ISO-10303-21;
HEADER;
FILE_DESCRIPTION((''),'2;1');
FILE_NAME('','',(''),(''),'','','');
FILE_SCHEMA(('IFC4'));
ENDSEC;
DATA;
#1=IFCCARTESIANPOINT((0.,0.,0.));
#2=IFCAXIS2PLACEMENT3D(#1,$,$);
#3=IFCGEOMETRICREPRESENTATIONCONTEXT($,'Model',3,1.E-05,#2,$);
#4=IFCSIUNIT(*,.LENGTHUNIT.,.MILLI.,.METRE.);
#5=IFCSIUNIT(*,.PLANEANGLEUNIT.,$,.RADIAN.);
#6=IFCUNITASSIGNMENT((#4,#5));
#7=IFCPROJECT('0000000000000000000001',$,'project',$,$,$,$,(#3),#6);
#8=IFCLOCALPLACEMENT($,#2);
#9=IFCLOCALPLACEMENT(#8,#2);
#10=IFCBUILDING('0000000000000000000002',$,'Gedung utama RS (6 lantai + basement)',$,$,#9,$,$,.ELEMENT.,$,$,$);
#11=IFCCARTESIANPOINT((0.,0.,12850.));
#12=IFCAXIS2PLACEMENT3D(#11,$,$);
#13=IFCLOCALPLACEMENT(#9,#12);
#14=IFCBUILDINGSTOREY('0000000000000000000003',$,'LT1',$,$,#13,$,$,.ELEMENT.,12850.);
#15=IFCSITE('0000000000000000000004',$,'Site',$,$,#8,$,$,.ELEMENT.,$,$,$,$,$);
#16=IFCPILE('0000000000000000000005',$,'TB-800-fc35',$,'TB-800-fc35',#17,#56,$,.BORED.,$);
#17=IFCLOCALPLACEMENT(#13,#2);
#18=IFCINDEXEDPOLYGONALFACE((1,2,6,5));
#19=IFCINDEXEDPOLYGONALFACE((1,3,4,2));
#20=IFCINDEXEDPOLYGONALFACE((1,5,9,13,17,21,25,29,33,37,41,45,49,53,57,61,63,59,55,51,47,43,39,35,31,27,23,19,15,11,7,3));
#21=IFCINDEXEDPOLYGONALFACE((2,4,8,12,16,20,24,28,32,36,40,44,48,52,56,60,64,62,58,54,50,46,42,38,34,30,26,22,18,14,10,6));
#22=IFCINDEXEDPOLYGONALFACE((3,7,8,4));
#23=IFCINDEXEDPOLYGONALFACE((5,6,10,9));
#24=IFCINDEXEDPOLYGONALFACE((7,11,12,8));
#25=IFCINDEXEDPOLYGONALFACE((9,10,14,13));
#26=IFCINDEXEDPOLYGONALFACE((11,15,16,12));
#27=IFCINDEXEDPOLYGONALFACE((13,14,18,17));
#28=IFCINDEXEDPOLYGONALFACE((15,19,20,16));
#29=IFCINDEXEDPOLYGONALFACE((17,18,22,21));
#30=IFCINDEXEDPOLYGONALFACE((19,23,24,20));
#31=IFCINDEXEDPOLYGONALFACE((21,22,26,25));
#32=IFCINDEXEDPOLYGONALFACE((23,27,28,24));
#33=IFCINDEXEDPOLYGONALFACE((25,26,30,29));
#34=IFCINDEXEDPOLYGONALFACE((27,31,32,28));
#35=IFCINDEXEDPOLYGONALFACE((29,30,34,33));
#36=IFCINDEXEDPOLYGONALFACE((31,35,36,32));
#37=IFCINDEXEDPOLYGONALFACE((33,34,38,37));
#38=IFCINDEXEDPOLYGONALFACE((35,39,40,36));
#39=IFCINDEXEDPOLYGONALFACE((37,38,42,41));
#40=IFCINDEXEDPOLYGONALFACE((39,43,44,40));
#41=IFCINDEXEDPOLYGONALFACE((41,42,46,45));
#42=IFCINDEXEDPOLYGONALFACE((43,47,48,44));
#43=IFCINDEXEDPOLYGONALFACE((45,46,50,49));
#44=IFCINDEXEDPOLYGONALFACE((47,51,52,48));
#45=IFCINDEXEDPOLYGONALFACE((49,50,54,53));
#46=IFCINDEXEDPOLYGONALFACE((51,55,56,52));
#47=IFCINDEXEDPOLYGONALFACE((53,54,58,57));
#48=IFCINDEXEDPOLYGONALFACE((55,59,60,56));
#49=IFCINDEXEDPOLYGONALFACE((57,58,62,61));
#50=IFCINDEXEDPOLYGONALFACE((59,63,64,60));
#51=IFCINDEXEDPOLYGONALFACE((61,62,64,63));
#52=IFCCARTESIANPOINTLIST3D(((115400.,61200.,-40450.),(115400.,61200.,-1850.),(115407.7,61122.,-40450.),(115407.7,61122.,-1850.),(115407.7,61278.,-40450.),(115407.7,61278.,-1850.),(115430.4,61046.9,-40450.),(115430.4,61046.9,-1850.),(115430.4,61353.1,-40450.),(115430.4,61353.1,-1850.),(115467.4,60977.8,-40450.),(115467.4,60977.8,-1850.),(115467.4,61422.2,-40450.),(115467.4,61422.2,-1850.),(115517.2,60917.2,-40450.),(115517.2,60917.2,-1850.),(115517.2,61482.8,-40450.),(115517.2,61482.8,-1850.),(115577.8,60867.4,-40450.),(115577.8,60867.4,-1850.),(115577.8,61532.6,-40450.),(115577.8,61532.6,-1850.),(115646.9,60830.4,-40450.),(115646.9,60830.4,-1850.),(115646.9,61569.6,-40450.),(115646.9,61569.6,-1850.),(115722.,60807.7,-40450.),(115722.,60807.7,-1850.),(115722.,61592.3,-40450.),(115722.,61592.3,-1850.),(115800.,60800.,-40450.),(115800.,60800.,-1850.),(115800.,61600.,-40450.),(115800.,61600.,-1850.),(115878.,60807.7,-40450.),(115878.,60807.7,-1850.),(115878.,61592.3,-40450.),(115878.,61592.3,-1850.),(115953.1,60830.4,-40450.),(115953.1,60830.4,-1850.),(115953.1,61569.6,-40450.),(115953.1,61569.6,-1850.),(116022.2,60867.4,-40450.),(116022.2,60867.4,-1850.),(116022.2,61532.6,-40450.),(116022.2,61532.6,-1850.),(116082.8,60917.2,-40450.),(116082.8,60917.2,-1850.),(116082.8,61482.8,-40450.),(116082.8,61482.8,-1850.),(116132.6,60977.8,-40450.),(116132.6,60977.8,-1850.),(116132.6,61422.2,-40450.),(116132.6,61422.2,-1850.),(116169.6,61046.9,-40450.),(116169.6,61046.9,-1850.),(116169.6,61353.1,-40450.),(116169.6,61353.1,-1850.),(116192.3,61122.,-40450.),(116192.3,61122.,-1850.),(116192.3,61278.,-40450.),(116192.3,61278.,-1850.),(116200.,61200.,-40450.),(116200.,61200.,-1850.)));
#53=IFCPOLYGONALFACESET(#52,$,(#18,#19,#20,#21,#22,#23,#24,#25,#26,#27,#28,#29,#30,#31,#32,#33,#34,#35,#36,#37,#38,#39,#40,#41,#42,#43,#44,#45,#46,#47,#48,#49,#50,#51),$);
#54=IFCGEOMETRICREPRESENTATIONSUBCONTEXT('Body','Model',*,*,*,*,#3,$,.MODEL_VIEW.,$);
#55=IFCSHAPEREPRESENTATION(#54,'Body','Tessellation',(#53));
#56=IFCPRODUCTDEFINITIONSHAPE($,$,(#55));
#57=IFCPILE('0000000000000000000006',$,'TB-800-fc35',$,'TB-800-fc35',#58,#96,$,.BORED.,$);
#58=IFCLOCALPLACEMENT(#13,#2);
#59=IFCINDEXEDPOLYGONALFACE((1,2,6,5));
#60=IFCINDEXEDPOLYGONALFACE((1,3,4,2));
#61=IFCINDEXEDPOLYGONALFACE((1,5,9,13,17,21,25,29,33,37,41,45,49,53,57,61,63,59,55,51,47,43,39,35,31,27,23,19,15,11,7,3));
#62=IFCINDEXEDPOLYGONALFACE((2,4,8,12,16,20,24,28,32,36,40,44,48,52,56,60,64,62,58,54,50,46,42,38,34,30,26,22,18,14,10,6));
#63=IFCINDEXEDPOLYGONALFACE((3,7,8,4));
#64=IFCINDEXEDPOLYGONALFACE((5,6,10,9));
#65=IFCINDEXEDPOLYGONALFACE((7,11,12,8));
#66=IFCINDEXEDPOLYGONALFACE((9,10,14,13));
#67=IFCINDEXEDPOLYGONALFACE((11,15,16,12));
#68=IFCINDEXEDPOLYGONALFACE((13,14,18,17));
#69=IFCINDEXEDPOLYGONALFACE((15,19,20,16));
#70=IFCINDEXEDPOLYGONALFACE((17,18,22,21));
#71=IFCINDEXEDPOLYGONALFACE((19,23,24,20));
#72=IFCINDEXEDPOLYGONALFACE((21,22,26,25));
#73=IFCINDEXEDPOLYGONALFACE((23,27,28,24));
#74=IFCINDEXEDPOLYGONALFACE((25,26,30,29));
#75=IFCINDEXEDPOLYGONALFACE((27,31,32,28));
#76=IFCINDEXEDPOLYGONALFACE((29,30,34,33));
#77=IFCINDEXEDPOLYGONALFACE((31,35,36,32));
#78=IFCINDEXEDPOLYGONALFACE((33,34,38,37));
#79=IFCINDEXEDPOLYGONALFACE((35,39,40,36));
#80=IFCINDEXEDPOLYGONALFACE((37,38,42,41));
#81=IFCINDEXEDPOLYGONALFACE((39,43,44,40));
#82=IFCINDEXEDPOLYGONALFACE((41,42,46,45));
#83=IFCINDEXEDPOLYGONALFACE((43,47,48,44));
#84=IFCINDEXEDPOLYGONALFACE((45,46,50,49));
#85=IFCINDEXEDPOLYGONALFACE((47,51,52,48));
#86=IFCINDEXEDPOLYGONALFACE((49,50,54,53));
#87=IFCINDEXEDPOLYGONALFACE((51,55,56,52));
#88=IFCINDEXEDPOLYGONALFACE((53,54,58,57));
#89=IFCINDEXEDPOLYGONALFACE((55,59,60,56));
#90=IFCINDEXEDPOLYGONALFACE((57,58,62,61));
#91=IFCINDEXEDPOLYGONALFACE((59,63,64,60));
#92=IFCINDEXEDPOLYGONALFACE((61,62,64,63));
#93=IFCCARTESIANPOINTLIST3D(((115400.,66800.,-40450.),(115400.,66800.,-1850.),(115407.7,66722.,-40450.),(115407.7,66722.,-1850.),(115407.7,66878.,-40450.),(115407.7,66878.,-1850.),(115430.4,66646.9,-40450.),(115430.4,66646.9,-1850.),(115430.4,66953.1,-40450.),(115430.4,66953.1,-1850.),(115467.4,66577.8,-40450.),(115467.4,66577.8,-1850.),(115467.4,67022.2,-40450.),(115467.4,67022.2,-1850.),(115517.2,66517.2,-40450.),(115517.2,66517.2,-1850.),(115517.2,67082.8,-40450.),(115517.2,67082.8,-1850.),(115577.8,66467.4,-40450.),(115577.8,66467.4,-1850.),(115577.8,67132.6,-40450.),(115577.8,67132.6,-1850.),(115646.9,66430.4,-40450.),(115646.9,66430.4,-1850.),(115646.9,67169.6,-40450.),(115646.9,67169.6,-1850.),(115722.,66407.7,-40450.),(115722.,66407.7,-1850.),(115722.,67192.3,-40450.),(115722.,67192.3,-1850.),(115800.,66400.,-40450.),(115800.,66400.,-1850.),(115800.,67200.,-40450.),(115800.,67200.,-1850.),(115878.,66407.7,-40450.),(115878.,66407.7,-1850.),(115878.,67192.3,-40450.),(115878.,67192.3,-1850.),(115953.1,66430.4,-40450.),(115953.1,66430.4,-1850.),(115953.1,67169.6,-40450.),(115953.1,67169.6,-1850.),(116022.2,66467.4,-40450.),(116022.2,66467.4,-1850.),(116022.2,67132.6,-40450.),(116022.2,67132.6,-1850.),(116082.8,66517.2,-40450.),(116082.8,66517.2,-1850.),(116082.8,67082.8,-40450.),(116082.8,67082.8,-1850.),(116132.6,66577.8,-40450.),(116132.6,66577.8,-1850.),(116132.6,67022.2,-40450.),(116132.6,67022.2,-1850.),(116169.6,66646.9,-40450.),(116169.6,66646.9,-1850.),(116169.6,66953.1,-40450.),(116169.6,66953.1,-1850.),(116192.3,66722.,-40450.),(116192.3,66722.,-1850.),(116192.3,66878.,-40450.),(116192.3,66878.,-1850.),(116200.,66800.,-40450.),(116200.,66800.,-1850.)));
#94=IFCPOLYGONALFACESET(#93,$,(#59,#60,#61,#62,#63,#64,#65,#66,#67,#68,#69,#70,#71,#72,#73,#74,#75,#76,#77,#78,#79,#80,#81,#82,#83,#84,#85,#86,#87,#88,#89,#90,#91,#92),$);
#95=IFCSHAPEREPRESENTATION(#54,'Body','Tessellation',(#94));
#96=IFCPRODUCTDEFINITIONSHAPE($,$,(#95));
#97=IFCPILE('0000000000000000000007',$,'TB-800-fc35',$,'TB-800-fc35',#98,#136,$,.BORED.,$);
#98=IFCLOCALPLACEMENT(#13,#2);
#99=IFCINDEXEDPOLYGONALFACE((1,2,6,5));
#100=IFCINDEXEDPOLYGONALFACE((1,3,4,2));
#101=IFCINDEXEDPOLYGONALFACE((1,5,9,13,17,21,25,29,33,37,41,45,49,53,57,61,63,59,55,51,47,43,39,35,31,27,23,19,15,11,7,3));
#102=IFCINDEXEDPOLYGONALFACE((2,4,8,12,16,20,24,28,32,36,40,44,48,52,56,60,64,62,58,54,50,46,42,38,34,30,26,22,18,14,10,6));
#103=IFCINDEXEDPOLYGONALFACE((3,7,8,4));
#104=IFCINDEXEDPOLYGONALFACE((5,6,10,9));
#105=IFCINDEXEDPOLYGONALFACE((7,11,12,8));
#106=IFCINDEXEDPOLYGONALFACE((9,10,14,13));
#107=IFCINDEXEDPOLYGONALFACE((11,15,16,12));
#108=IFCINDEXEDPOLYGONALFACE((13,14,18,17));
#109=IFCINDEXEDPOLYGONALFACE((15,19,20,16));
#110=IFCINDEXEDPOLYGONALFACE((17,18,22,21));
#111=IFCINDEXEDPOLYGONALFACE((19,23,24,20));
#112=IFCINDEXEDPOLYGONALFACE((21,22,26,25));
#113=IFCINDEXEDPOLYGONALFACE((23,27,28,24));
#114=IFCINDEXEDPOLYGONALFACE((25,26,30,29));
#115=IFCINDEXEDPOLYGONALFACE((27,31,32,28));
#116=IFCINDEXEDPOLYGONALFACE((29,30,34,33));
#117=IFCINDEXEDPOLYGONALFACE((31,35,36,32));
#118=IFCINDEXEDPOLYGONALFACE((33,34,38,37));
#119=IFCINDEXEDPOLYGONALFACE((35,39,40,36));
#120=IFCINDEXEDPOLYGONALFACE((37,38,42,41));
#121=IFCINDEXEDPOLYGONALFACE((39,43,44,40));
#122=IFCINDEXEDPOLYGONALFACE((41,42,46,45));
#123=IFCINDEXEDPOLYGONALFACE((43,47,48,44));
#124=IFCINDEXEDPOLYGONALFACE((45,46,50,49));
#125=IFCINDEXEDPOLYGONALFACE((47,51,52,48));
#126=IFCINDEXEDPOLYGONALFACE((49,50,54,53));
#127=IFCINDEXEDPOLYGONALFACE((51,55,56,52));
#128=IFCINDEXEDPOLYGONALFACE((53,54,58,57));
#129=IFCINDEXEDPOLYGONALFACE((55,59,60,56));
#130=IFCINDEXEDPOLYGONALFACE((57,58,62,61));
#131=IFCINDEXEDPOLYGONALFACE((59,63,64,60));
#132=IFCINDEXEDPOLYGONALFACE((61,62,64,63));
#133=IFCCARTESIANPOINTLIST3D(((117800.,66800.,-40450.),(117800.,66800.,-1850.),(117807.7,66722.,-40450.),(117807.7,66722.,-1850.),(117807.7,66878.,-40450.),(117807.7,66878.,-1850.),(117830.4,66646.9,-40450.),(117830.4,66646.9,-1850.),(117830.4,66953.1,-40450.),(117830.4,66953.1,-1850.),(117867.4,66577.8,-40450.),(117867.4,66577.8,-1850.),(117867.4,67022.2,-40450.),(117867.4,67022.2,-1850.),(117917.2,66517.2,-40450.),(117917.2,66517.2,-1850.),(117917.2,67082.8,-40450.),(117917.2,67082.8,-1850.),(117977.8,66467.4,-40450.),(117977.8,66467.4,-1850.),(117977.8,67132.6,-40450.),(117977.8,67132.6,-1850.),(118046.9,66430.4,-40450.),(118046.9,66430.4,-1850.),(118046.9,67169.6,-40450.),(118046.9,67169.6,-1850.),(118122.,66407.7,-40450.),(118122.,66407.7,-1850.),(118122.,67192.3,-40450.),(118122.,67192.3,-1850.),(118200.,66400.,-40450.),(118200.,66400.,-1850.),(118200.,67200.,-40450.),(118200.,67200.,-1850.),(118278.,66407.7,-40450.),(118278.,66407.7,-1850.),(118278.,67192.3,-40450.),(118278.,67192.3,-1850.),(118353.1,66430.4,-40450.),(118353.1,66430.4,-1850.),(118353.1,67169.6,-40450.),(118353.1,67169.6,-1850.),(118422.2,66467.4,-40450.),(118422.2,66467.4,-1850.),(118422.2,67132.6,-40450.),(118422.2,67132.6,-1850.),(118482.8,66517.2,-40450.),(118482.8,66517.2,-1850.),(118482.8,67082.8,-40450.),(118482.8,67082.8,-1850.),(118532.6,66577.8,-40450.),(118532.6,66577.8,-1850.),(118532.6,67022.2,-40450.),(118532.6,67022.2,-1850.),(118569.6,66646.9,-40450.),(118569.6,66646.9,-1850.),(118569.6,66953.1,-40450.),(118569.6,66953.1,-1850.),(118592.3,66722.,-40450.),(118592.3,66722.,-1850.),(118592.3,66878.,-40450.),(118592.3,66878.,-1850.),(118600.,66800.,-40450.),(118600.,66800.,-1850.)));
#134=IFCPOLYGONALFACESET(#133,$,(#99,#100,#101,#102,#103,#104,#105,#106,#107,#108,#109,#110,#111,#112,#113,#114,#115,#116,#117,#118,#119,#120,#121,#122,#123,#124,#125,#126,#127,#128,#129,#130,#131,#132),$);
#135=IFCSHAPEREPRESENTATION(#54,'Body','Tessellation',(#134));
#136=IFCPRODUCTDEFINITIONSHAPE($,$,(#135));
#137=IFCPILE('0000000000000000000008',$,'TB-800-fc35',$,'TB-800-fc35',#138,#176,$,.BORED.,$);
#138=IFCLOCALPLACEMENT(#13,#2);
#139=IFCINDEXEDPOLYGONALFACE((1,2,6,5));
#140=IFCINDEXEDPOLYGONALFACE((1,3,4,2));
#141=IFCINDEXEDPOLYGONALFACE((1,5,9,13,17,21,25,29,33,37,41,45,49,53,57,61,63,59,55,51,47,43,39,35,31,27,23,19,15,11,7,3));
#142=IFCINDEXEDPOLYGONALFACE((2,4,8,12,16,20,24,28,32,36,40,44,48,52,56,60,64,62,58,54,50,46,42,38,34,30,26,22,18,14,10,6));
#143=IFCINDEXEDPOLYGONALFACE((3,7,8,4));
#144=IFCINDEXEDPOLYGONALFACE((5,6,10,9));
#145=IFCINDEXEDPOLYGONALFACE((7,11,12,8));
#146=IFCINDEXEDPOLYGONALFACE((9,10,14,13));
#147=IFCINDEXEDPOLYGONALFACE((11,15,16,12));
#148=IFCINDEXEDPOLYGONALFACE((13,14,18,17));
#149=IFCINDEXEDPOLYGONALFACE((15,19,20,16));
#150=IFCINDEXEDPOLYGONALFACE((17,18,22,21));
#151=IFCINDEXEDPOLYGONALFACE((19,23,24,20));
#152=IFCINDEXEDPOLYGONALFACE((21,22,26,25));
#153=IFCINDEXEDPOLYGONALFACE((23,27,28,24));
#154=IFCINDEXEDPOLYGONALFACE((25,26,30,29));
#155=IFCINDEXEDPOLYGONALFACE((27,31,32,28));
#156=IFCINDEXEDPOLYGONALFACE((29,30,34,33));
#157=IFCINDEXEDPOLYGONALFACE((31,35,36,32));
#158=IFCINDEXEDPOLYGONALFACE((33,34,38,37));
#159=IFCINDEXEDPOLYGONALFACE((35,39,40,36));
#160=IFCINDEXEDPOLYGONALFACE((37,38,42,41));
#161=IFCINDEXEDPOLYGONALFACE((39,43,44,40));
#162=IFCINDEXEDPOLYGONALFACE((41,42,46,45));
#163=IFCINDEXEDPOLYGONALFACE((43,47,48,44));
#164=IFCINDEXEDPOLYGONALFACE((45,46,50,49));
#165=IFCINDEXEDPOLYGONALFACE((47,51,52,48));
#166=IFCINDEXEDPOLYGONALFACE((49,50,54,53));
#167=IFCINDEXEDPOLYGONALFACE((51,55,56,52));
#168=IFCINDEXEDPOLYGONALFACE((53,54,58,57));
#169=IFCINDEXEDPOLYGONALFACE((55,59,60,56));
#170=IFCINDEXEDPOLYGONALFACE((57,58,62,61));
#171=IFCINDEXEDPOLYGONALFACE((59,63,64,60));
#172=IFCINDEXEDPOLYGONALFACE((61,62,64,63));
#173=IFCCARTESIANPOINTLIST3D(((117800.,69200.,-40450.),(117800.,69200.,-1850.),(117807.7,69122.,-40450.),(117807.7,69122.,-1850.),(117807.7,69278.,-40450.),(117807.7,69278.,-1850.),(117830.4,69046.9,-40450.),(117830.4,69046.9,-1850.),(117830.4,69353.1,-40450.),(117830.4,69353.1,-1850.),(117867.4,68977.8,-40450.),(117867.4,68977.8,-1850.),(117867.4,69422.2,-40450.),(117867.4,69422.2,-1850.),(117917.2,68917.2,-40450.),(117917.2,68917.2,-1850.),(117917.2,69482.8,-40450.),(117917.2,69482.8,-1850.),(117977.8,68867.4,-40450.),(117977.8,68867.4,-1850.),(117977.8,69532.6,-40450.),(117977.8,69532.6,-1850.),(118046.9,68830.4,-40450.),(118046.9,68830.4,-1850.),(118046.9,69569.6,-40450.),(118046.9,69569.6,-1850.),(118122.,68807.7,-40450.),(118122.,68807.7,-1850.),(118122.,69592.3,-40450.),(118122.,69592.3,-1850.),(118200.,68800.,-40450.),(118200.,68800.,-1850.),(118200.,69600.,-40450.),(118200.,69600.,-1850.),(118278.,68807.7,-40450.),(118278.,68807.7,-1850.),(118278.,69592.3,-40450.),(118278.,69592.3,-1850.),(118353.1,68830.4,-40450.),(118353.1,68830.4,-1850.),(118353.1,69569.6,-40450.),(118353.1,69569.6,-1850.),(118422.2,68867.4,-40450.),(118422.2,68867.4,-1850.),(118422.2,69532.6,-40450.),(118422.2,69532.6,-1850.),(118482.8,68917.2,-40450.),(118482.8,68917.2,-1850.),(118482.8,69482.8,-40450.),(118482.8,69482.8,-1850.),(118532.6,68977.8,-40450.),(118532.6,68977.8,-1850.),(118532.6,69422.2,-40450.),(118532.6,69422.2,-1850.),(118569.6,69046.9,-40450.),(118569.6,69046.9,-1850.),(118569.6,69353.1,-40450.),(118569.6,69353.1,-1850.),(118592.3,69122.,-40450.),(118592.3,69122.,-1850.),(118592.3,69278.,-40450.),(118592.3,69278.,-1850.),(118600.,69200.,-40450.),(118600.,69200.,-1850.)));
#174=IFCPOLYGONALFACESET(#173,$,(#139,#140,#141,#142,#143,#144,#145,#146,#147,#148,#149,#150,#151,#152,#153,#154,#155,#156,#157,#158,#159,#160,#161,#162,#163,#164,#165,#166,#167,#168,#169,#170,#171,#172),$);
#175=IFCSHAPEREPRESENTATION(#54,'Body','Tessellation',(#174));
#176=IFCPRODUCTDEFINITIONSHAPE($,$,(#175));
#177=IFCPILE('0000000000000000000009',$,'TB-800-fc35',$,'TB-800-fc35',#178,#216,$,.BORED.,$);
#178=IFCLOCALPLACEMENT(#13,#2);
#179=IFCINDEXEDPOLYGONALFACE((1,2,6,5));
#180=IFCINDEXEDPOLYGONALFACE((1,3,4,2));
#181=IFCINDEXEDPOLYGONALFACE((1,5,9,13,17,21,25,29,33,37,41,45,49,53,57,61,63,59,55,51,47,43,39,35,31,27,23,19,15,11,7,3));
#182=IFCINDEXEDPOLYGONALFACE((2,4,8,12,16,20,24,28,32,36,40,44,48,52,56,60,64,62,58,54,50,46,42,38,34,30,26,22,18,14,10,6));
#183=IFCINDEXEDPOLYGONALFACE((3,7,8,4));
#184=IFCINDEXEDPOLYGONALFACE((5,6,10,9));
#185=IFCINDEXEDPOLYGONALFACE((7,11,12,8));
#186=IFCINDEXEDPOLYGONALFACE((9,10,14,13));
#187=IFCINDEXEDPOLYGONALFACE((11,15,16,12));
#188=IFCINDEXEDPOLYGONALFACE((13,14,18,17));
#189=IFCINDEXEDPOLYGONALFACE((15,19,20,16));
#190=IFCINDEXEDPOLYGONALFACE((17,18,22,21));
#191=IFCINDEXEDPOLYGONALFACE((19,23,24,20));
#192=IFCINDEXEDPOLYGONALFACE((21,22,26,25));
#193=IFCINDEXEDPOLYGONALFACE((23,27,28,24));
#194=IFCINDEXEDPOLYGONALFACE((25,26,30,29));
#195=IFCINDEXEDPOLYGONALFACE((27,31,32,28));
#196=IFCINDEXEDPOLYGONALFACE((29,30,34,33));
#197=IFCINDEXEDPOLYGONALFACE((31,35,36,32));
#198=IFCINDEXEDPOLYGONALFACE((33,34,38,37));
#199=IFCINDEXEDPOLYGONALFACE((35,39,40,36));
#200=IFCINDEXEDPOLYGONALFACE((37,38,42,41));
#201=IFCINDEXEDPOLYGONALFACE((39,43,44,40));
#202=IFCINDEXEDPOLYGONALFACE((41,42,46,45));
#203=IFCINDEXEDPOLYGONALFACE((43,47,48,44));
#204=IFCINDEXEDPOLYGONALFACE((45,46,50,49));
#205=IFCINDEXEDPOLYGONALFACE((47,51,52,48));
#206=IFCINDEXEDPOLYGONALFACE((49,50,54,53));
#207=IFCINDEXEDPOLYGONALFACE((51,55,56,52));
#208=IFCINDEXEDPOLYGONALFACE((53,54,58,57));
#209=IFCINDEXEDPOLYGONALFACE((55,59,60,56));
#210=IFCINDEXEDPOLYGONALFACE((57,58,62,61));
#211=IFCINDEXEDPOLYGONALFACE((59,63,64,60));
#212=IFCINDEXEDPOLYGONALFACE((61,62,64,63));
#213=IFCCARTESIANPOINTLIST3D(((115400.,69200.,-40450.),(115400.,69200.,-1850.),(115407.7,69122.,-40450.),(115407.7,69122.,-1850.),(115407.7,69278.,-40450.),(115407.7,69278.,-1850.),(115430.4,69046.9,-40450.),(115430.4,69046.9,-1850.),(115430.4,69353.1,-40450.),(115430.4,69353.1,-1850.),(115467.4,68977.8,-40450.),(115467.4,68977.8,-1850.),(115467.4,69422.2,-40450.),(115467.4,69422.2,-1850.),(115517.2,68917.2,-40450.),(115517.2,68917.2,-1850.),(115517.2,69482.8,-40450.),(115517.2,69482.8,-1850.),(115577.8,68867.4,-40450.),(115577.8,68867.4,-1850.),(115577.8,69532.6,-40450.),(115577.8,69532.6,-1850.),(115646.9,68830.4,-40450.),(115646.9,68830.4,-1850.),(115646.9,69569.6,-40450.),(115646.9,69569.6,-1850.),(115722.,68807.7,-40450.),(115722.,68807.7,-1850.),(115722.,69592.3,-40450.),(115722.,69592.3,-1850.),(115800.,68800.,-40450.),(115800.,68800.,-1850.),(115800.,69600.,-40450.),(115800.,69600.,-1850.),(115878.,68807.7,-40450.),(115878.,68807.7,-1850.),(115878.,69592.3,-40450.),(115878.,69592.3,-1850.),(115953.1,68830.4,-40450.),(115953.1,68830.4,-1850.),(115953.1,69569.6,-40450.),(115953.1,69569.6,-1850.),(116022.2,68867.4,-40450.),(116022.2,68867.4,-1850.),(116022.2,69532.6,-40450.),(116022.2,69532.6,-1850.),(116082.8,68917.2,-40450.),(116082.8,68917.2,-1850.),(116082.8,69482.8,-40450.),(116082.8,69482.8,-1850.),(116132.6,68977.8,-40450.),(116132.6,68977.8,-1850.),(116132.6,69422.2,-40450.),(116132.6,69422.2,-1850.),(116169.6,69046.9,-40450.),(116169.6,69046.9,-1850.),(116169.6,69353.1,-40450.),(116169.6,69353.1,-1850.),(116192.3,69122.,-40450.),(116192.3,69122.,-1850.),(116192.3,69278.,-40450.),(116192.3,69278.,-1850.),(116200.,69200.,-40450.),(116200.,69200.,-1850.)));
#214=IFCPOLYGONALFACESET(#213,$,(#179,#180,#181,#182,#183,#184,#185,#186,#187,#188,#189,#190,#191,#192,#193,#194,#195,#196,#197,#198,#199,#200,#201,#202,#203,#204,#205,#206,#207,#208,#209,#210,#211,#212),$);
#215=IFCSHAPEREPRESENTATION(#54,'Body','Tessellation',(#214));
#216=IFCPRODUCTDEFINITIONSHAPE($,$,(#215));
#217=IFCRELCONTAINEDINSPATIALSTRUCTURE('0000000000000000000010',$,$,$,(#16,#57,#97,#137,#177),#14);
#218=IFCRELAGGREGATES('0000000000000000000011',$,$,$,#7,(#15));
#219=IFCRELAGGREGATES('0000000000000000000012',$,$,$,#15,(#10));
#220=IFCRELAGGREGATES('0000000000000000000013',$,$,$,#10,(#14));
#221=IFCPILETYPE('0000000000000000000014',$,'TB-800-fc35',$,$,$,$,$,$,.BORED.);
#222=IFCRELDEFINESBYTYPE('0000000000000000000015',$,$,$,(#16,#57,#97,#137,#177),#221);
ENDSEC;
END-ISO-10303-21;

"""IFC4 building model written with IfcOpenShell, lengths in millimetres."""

from ifc_helpers import new_model, si_unit, frame, origin, origin_2d, place, context, subcontext, project, spatial, circle, extrude, material_profile, profile_set, profile_usage, type_object, element, save


model = new_model("IFC4")

# Units and contexts
model_context = context("Model", 3, precision=1e-05, world=origin())
body_context = subcontext(model_context, "Body", "Model", "MODEL_VIEW")
ifc_project = project(units=[si_unit("LENGTHUNIT", "METRE", prefix="MILLI"), si_unit("PLANEANGLEUNIT", "RADIAN")], contexts=[model_context])

# Site, building, storey
site_placement = place(None, origin())
site = spatial("IfcSite", under=ifc_project, at=site_placement, Name="Site", CompositionType="ELEMENT")
building_placement = place(site_placement, origin())
building = spatial("IfcBuilding", under=site, at=building_placement, Name="Gedung utama RS (6 lantai + basement)", CompositionType="ELEMENT")
storey_placement = place(building_placement, frame((0.0, 0.0, 12850.0)))
storey = spatial("IfcBuildingStorey", under=building, at=storey_placement, Name="LT1", CompositionType="ELEMENT", Elevation=12850.0)

# Piles
ifc_material_profile = material_profile(None, circle(Radius=400.0, at=origin_2d()), Name="TB-800-fc35")
ifc_profile_set = profile_set([ifc_material_profile], Name="TB-800-fc35")
ifc_profile_usage = profile_usage(ifc_profile_set, cardinal=5)
pile_type = type_object("IfcPileType", Name="TB-800-fc35", PredefinedType="BORED", material=ifc_profile_set)
for number, where, z_axis, x_axis, name in (
    (1, (115800.0, 61200.0, -40450.0), (0.0, 0.0, 1.0), (1.0, 0.0, 0.0), "TB-800-fc35"),
    (2, (115800.0, 66800.0, -40450.0), (0.0, 0.0, 1.0), (1.0, 0.0, 0.0), "TB-800-fc35"),
    (3, (118200.0, 66800.0, -40450.0), (0.0, 0.0, 1.0), (1.0, 0.0, 0.0), "TB-800-fc35"),
    (4, (118200.0, 69200.0, -40450.0), (0.0, 0.0, 1.0), (1.0, 0.0, 0.0), "TB-800-fc35"),
    (5, (115800.0, 69200.0, -40450.0), (0.0, 0.0, 1.0), (1.0, 0.0, 0.0), "TB-800-fc35"),
):
    element("IfcPile", number, at=place(storey_placement, frame(where, z_axis=z_axis, x_axis=x_axis)), inside=storey, type_object=pile_type, material=ifc_profile_usage, Name=name, ObjectType="TB-800-fc35", PredefinedType="BORED", context=body_context, shape_type="SweptSolid", body=[
        extrude(circle(Radius=400.0, at=origin_2d()), origin(), (0.0, 0.0, 1.0), 38600.0),
    ])

save(model, "model.ifc")
